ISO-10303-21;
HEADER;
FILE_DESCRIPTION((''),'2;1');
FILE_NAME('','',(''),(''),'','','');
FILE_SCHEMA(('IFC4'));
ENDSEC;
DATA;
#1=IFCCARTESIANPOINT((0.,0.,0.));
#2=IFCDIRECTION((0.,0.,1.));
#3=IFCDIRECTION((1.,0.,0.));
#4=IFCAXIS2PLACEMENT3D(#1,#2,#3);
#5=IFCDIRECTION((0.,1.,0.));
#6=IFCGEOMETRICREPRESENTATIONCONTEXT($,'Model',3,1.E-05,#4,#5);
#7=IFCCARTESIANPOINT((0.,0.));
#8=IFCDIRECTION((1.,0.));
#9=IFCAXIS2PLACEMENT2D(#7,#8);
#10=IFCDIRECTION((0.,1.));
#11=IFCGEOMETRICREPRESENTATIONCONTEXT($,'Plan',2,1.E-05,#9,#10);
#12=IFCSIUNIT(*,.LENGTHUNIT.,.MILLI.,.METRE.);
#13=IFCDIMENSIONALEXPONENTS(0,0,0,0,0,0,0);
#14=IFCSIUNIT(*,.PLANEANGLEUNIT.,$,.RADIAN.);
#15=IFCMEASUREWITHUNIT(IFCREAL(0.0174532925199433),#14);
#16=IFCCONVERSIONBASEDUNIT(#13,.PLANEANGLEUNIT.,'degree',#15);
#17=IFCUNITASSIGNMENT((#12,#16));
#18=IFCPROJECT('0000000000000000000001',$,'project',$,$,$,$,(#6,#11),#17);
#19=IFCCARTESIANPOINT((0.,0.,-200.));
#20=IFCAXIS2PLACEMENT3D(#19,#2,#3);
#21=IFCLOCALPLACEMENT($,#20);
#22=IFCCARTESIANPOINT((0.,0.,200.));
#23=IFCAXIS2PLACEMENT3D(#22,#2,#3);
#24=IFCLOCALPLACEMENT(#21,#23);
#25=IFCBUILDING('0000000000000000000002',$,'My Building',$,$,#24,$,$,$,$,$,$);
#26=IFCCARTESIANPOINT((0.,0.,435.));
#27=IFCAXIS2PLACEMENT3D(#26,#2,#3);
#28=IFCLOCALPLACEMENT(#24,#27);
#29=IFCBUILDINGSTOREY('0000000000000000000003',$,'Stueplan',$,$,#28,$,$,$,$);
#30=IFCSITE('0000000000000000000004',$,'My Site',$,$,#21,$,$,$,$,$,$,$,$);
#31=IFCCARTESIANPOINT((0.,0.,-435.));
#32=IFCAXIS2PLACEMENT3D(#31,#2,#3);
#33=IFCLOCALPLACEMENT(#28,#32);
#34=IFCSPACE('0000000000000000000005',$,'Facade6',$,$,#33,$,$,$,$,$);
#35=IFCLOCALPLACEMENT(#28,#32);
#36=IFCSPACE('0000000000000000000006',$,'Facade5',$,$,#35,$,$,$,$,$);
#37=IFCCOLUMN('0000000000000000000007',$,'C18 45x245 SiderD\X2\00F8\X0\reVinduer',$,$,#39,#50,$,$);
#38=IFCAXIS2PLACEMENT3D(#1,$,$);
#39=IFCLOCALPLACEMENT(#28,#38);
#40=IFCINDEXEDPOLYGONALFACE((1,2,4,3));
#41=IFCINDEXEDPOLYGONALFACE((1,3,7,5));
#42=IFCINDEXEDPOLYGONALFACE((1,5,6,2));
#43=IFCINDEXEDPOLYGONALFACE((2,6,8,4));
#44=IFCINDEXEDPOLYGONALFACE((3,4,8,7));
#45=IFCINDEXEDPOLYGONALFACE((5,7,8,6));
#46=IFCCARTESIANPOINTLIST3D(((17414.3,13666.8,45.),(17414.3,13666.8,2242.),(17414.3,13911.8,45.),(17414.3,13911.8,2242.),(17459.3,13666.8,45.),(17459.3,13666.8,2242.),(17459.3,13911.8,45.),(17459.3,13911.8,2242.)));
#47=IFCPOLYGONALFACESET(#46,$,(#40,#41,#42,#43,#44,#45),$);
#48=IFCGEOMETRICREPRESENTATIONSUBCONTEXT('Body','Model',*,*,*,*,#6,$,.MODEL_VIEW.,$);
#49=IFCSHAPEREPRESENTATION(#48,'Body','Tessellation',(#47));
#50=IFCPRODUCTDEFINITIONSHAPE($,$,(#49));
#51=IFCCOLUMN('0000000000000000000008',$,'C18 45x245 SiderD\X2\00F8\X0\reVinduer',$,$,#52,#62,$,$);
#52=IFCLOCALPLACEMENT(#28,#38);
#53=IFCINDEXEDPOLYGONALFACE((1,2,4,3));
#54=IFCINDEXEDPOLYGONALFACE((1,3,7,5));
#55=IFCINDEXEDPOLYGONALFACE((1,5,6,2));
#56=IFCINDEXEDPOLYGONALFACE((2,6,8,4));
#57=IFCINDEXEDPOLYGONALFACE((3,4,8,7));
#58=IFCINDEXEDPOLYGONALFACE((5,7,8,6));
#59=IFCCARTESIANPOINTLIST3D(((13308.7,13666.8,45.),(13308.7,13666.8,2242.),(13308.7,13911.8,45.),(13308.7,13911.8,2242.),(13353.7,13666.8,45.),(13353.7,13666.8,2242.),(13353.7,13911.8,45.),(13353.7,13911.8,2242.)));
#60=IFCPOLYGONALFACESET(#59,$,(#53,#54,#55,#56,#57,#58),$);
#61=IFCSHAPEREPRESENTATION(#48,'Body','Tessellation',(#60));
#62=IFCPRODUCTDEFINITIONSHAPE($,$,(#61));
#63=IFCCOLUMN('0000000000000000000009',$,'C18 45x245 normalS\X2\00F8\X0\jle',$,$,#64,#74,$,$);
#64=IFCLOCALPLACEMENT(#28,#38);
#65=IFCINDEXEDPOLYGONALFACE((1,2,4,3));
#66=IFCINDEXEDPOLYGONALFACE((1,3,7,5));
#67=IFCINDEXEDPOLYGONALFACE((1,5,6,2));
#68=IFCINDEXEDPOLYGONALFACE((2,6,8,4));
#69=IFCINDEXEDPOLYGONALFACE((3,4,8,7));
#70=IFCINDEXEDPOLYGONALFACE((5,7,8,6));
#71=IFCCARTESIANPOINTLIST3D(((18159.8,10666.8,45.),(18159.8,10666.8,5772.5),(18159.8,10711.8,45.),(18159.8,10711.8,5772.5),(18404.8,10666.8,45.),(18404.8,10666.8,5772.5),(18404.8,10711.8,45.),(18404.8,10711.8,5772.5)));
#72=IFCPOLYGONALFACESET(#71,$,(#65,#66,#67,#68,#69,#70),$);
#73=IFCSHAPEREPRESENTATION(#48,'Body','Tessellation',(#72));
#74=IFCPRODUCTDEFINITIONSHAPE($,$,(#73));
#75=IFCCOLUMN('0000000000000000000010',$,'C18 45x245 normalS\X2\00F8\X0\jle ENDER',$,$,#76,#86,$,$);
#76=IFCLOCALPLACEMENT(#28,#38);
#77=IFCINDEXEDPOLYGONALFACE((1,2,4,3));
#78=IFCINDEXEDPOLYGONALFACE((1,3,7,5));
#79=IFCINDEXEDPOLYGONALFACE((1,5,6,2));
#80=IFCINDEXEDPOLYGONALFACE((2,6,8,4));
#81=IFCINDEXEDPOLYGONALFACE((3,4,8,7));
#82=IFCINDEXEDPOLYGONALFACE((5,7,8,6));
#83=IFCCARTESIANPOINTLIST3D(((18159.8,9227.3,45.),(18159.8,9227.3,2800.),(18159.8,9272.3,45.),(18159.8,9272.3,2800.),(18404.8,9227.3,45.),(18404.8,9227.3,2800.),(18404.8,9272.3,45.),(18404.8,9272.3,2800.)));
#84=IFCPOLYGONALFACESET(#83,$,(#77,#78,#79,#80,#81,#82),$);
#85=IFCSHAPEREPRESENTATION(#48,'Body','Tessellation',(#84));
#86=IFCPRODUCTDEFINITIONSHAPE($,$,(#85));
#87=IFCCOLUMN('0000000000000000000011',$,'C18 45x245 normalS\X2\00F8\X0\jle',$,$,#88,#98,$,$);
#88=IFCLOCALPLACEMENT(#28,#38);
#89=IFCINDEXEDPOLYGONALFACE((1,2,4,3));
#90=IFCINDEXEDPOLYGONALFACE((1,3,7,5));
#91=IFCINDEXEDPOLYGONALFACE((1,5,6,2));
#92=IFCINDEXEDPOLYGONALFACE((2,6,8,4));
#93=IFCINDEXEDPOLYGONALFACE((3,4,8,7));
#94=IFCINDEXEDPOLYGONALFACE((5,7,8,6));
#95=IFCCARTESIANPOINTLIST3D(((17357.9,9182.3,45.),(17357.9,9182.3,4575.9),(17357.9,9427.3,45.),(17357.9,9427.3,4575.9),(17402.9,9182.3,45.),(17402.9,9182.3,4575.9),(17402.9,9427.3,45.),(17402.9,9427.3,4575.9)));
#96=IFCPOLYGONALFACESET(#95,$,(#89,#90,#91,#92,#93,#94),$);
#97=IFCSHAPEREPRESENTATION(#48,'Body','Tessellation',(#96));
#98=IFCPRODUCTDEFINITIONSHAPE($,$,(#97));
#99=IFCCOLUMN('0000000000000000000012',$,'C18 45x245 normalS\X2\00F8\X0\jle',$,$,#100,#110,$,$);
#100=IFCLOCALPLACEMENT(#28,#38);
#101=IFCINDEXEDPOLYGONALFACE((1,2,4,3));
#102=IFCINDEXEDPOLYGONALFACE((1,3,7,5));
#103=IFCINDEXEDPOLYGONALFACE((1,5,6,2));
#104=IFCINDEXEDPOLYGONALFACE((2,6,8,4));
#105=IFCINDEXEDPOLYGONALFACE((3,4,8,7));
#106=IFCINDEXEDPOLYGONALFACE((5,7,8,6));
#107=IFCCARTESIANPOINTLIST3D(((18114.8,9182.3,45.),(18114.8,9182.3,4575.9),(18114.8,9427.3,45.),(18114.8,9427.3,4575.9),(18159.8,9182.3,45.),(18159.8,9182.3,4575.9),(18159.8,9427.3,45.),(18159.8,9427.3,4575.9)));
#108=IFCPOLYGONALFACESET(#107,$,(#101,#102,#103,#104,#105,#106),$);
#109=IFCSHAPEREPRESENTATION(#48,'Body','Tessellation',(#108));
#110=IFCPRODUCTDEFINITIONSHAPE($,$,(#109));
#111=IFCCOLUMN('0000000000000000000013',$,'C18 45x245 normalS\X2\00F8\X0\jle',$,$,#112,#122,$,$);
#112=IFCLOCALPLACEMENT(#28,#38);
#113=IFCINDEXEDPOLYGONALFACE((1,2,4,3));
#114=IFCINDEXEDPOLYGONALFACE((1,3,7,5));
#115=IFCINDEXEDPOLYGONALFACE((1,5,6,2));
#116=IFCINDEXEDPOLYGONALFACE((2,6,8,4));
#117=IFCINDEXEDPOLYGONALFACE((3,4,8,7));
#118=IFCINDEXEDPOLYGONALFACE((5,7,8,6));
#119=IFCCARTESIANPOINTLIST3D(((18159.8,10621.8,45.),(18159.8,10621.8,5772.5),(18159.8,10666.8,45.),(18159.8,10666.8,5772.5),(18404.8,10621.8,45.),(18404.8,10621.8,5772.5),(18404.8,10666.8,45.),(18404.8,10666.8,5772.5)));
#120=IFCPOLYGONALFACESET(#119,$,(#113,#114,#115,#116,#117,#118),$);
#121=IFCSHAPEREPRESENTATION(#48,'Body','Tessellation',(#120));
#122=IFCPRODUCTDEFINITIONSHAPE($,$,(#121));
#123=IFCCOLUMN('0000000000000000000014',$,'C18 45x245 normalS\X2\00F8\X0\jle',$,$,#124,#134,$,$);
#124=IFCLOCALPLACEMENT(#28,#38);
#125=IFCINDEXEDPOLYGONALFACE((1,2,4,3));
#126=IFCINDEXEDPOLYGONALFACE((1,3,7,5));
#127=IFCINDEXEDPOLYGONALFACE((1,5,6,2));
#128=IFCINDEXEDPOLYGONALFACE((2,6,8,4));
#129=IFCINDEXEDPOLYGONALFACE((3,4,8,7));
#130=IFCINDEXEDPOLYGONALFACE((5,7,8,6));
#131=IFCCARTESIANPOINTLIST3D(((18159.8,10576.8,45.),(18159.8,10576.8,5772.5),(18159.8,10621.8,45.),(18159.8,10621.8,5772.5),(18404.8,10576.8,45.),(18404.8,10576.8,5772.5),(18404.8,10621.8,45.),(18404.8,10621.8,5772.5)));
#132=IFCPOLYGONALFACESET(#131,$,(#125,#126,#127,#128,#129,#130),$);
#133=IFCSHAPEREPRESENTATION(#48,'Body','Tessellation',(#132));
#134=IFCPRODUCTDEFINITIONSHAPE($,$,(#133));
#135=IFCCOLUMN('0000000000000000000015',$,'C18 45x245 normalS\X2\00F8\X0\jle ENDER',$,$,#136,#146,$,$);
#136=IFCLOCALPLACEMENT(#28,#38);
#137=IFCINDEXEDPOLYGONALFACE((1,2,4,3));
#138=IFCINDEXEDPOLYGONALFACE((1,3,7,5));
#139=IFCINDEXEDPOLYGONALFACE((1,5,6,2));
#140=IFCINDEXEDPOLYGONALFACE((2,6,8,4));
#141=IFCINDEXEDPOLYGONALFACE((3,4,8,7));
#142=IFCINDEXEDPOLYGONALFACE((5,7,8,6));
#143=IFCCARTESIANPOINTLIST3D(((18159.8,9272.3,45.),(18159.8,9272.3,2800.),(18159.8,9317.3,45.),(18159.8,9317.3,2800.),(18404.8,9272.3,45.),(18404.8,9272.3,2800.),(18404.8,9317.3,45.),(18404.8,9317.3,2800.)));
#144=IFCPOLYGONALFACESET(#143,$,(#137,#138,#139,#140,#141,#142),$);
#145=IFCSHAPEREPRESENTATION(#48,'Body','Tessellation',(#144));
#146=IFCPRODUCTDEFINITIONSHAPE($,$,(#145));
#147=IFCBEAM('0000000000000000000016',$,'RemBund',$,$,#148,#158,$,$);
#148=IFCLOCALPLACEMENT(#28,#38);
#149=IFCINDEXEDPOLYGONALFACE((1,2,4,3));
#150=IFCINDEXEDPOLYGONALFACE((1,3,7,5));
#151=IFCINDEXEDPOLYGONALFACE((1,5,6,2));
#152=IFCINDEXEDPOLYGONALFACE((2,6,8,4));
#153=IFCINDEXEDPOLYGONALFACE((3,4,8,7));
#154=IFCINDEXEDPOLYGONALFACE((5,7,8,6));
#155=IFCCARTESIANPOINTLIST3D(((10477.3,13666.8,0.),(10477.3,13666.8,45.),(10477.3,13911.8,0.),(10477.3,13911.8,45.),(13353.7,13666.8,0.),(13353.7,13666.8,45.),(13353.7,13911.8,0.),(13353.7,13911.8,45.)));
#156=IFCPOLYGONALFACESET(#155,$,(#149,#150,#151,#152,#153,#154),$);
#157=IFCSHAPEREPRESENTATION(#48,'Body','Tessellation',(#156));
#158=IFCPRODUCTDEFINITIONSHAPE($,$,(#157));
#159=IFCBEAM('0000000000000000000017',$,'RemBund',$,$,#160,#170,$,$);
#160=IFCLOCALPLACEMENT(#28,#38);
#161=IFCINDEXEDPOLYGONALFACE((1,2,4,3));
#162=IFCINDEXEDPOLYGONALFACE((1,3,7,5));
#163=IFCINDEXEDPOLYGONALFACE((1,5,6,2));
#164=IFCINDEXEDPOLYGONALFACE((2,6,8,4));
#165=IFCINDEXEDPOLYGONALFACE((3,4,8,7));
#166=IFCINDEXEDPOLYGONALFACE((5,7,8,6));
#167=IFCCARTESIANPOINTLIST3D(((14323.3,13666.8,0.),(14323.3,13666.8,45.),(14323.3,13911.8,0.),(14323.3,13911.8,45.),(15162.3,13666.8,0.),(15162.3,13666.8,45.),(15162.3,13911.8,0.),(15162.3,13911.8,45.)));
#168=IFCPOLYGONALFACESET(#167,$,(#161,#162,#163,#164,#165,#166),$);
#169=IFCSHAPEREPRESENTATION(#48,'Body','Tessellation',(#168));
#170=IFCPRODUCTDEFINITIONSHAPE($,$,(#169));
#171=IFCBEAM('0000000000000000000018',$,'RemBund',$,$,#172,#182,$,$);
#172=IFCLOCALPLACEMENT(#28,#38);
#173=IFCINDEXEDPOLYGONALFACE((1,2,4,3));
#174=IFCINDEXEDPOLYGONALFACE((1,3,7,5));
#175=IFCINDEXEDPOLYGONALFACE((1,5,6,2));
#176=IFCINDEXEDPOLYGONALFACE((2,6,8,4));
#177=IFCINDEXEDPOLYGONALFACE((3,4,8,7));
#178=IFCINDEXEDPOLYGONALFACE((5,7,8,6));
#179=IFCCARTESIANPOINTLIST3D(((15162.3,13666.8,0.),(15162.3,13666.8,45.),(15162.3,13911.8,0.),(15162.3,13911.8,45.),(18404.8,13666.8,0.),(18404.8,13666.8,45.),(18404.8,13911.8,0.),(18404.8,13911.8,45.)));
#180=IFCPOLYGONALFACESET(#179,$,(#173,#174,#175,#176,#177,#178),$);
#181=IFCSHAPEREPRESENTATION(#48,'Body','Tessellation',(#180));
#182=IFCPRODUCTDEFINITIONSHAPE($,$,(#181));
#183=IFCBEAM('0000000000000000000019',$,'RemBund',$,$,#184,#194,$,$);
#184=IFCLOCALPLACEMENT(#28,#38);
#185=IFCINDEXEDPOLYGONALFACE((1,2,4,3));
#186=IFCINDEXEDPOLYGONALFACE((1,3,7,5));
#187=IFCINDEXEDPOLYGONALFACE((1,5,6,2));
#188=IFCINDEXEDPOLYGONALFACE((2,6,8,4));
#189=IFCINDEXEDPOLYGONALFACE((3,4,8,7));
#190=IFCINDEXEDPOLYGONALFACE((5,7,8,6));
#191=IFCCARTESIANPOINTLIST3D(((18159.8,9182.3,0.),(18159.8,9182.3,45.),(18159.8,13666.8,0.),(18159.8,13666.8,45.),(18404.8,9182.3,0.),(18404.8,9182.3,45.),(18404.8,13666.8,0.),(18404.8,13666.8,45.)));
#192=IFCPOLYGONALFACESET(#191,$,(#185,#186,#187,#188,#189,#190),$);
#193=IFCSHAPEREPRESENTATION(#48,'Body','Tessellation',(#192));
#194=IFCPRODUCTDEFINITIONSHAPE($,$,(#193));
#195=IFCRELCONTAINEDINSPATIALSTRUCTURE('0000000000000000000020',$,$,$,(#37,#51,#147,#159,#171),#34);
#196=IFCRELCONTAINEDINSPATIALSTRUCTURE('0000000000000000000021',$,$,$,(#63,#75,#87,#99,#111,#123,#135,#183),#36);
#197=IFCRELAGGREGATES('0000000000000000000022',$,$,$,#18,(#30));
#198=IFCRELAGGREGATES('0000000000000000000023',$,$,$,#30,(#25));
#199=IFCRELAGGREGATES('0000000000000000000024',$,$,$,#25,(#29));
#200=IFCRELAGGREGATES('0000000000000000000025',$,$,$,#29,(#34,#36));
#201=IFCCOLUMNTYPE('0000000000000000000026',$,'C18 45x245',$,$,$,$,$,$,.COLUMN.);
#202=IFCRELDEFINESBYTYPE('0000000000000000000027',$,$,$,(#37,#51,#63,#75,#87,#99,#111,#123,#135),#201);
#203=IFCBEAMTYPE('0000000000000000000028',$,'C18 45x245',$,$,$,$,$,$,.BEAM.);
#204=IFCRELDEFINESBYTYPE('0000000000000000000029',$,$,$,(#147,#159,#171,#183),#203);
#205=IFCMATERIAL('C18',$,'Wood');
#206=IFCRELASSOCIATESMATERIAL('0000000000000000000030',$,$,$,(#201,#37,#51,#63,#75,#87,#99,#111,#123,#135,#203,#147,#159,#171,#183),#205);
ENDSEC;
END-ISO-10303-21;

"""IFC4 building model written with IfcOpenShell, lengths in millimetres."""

from ifc_helpers import new_model, entity, si_unit, converted_unit, direction, frame, origin_with_axes, origin_2d_with_axis, place, context, subcontext, project, spatial, rectangle, extrude, material, material_profile, profile_set, profile_usage, type_object, element, save


model = new_model("IFC4")

# Units and contexts
model_context = context("Model", 3, precision=1e-05, world=origin_with_axes(), true_north=direction((0.0, 1.0, 0.0)))
plan_context = context("Plan", 2, precision=1e-05, world=origin_2d_with_axis(), true_north=direction((0.0, 1.0)))
body_context_1 = subcontext(model_context, "Body", "Model", "MODEL_VIEW")
ifc_project = project(units=[si_unit("LENGTHUNIT", "METRE", prefix="MILLI"), converted_unit("PLANEANGLEUNIT", "degree", entity("IfcReal", 0.0174532925199433), si_unit("PLANEANGLEUNIT", "RADIAN"), dimensions=[0, 0, 0, 0, 0, 0, 0])], contexts=[model_context, plan_context])

# Site, building, storey
site_placement = place(None, frame((0.0, 0.0, -200.0), z_axis=(0.0, 0.0, 1.0), x_axis=(1.0, 0.0, 0.0)))
site = spatial("IfcSite", under=ifc_project, at=site_placement, Name="My Site")
building_placement = place(site_placement, frame((0.0, 0.0, 200.0), z_axis=(0.0, 0.0, 1.0), x_axis=(1.0, 0.0, 0.0)))
building = spatial("IfcBuilding", under=site, at=building_placement, Name="My Building")
storey_placement = place(building_placement, frame((0.0, 0.0, 435.0), z_axis=(0.0, 0.0, 1.0), x_axis=(1.0, 0.0, 0.0)))
storey = spatial("IfcBuildingStorey", under=building, at=storey_placement, Name="Stueplan")

# Shared definitions
ifc_material = material(Name="C18", Category="Wood")
ifc_material_profile_1 = material_profile(ifc_material, rectangle(XDim=45.0, YDim=245.0))
ifc_profile_set_1 = profile_set([ifc_material_profile_1], Name="woodStructural")
column_type = type_object("IfcColumnType", Name="C18 45x245", PredefinedType="COLUMN", material=ifc_profile_set_1)

# Shared definitions
space_1_placement = place(storey_placement, frame((0.0, 0.0, -435.0), z_axis=(0.0, 0.0, 1.0), x_axis=(1.0, 0.0, 0.0)))
space_1 = spatial("IfcSpace", under=storey, at=space_1_placement, Name="Facade6")

# Columns
ifc_profile_usage_1 = profile_usage(ifc_profile_set_1, cardinal=9)
column_1_placement = place(space_1_placement, frame((17414.3, 13911.8, 480.0), z_axis=(0.0, 0.0, 1.0), x_axis=(1.0, 0.0, 0.0)))
element("IfcColumn", 1, at=column_1_placement, inside=space_1, type_object=column_type, material=ifc_profile_usage_1, Name="C18 45x245 SiderDøreVinduer", context=body_context_1, shape_type="SweptSolid", body=[
    extrude(rectangle(XDim=45.0, YDim=245.0), frame((22.5, -122.5, 0.0), z_axis=(0.0, 0.0, 1.0), x_axis=(1.0, 0.0, 0.0)), (0.0, 0.0, 1.0), 2197.0),
])
ifc_profile_usage_2 = profile_usage(ifc_profile_set_1, cardinal=9)
column_2_placement = place(space_1_placement, frame((13308.7, 13911.8, 480.0), z_axis=(0.0, 0.0, 1.0), x_axis=(1.0, 0.0, 0.0)))
element("IfcColumn", 2, at=column_2_placement, inside=space_1, type_object=column_type, material=ifc_profile_usage_2, Name="C18 45x245 SiderDøreVinduer", context=body_context_1, shape_type="SweptSolid", body=[
    extrude(rectangle(XDim=45.0, YDim=245.0), frame((22.5, -122.5, 0.0), z_axis=(0.0, 0.0, 1.0), x_axis=(1.0, 0.0, 0.0)), (0.0, 0.0, 1.0), 2197.0),
])

# Shared definitions
space_2_placement = place(storey_placement, frame((0.0, 0.0, -435.0), z_axis=(0.0, 0.0, 1.0), x_axis=(1.0, 0.0, 0.0)))
space_2 = spatial("IfcSpace", under=storey, at=space_2_placement, Name="Facade5")

# Columns
ifc_profile_usage_3 = profile_usage(ifc_profile_set_1, cardinal=9)
column_3_placement = place(space_2_placement, frame((18159.8, 10666.8, 480.0), z_axis=(0.0, 0.0, 1.0), x_axis=(0.0, 1.0, 0.0)))
element("IfcColumn", 3, at=column_3_placement, inside=space_2, type_object=column_type, material=ifc_profile_usage_3, Name="C18 45x245 normalSøjle", context=body_context_1, shape_type="SweptSolid", body=[
    extrude(rectangle(XDim=45.0, YDim=245.0), frame((22.5, -122.5, 0.0), z_axis=(0.0, 0.0, 1.0), x_axis=(1.0, 0.0, 0.0)), (0.0, 0.0, 1.0), 5727.5),
])
ifc_profile_usage_4 = profile_usage(ifc_profile_set_1, cardinal=9)
column_4_placement = place(space_2_placement, frame((18159.8, 9227.3, 480.0), z_axis=(0.0, 0.0, 1.0), x_axis=(0.0, 1.0, 0.0)))
element("IfcColumn", 4, at=column_4_placement, inside=space_2, type_object=column_type, material=ifc_profile_usage_4, Name="C18 45x245 normalSøjle ENDER", context=body_context_1, shape_type="SweptSolid", body=[
    extrude(rectangle(XDim=45.0, YDim=245.0), frame((22.5, -122.5, 0.0), z_axis=(0.0, 0.0, 1.0), x_axis=(1.0, 0.0, 0.0)), (0.0, 0.0, 1.0), 2755.0),
])
ifc_profile_usage_5 = profile_usage(ifc_profile_set_1, cardinal=9)
column_5_placement = place(space_2_placement, frame((17402.9, 9182.3, 480.0), z_axis=(0.0, 0.0, 1.0), x_axis=(-1.0, 0.0, 0.0)))
element("IfcColumn", 5, at=column_5_placement, inside=space_2, type_object=column_type, material=ifc_profile_usage_5, Name="C18 45x245 normalSøjle", context=body_context_1, shape_type="SweptSolid", body=[
    extrude(rectangle(XDim=45.0, YDim=245.0), frame((22.5, -122.5, 0.0), z_axis=(0.0, 0.0, 1.0), x_axis=(1.0, 0.0, 0.0)), (0.0, 0.0, 1.0), 4530.9),
])
ifc_profile_usage_6 = profile_usage(ifc_profile_set_1, cardinal=9)
column_6_placement = place(space_2_placement, frame((18159.8, 9182.3, 480.0), z_axis=(0.0, 0.0, 1.0), x_axis=(-1.0, 0.0, 0.0)))
element("IfcColumn", 6, at=column_6_placement, inside=space_2, type_object=column_type, material=ifc_profile_usage_6, Name="C18 45x245 normalSøjle", context=body_context_1, shape_type="SweptSolid", body=[
    extrude(rectangle(XDim=45.0, YDim=245.0), frame((22.5, -122.5, 0.0), z_axis=(0.0, 0.0, 1.0), x_axis=(1.0, 0.0, 0.0)), (0.0, 0.0, 1.0), 4530.9),
])
ifc_profile_usage_7 = profile_usage(ifc_profile_set_1, cardinal=9)
column_7_placement = place(space_2_placement, frame((18159.8, 10621.8, 480.0), z_axis=(0.0, 0.0, 1.0), x_axis=(0.0, 1.0, 0.0)))
element("IfcColumn", 7, at=column_7_placement, inside=space_2, type_object=column_type, material=ifc_profile_usage_7, Name="C18 45x245 normalSøjle", context=body_context_1, shape_type="SweptSolid", body=[
    extrude(rectangle(XDim=45.0, YDim=245.0), frame((22.5, -122.5, 0.0), z_axis=(0.0, 0.0, 1.0), x_axis=(1.0, 0.0, 0.0)), (0.0, 0.0, 1.0), 5727.5),
])
ifc_profile_usage_8 = profile_usage(ifc_profile_set_1, cardinal=9)
column_8_placement = place(space_2_placement, frame((18159.8, 10576.8, 480.0), z_axis=(0.0, 0.0, 1.0), x_axis=(0.0, 1.0, 0.0)))
element("IfcColumn", 8, at=column_8_placement, inside=space_2, type_object=column_type, material=ifc_profile_usage_8, Name="C18 45x245 normalSøjle", context=body_context_1, shape_type="SweptSolid", body=[
    extrude(rectangle(XDim=45.0, YDim=245.0), frame((22.5, -122.5, 0.0), z_axis=(0.0, 0.0, 1.0), x_axis=(1.0, 0.0, 0.0)), (0.0, 0.0, 1.0), 5727.5),
])
ifc_profile_usage_9 = profile_usage(ifc_profile_set_1, cardinal=9)
column_9_placement = place(space_2_placement, frame((18159.8, 9272.3, 480.0), z_axis=(0.0, 0.0, 1.0), x_axis=(0.0, 1.0, 0.0)))
element("IfcColumn", 9, at=column_9_placement, inside=space_2, type_object=column_type, material=ifc_profile_usage_9, Name="C18 45x245 normalSøjle ENDER", context=body_context_1, shape_type="SweptSolid", body=[
    extrude(rectangle(XDim=45.0, YDim=245.0), frame((22.5, -122.5, 0.0), z_axis=(0.0, 0.0, 1.0), x_axis=(1.0, 0.0, 0.0)), (0.0, 0.0, 1.0), 2755.0),
])

# Beams
ifc_material_profile_2 = material_profile(ifc_material, rectangle(XDim=45.0, YDim=245.0), Name="concrete")
ifc_profile_set_2 = profile_set([ifc_material_profile_2], Name="woodStructural")
ifc_profile_usage_10 = profile_usage(ifc_profile_set_2)
beam_type_1 = type_object("IfcBeamType", Name="C18 45x245", PredefinedType="BEAM", material=ifc_profile_set_2)
beam_1_placement = place(space_1_placement, frame((13353.7, 13789.3, 457.5), z_axis=(-1.0, 0.0, 0.0), x_axis=(0.0, 0.0, 1.0)))
element("IfcBeam", 10, at=beam_1_placement, inside=space_1, type_object=beam_type_1, material=ifc_profile_usage_10, Name="RemBund", context=body_context_1, shape_type="SweptSolid", body=[
    extrude(rectangle(XDim=45.0, YDim=245.0), origin_with_axes(), (0.0, 0.0, 1.0), 2876.4),
])
ifc_profile_usage_11 = profile_usage(ifc_profile_set_2)
beam_2_placement = place(space_1_placement, frame((15162.3, 13789.3, 457.5), z_axis=(-1.0, 0.0, 0.0), x_axis=(0.0, 0.0, 1.0)))
element("IfcBeam", 11, at=beam_2_placement, inside=space_1, type_object=beam_type_1, material=ifc_profile_usage_11, Name="RemBund", context=body_context_1, shape_type="SweptSolid", body=[
    extrude(rectangle(XDim=45.0, YDim=245.0), origin_with_axes(), (0.0, 0.0, 1.0), 839.0),
])
ifc_profile_usage_12 = profile_usage(ifc_profile_set_2)
beam_3_placement = place(space_1_placement, frame((18404.8, 13789.3, 457.5), z_axis=(-1.0, 0.0, 0.0), x_axis=(0.0, 0.0, 1.0)))
element("IfcBeam", 12, at=beam_3_placement, inside=space_1, type_object=beam_type_1, material=ifc_profile_usage_12, Name="RemBund", context=body_context_1, shape_type="SweptSolid", body=[
    extrude(rectangle(XDim=45.0, YDim=245.0), origin_with_axes(), (0.0, 0.0, 1.0), 3242.5),
])
ifc_profile_usage_13 = profile_usage(ifc_profile_set_2)
beam_4_placement = place(space_2_placement, frame((18282.3, 13666.8, 457.5), z_axis=(0.0, -1.0, 0.0), x_axis=(0.0, 0.0, 1.0)))
element("IfcBeam", 13, at=beam_4_placement, inside=space_2, type_object=beam_type_1, material=ifc_profile_usage_13, Name="RemBund", context=body_context_1, shape_type="SweptSolid", body=[
    extrude(rectangle(XDim=45.0, YDim=245.0), origin_with_axes(), (0.0, 0.0, 1.0), 4484.5),
])

save(model, "model.ifc")
